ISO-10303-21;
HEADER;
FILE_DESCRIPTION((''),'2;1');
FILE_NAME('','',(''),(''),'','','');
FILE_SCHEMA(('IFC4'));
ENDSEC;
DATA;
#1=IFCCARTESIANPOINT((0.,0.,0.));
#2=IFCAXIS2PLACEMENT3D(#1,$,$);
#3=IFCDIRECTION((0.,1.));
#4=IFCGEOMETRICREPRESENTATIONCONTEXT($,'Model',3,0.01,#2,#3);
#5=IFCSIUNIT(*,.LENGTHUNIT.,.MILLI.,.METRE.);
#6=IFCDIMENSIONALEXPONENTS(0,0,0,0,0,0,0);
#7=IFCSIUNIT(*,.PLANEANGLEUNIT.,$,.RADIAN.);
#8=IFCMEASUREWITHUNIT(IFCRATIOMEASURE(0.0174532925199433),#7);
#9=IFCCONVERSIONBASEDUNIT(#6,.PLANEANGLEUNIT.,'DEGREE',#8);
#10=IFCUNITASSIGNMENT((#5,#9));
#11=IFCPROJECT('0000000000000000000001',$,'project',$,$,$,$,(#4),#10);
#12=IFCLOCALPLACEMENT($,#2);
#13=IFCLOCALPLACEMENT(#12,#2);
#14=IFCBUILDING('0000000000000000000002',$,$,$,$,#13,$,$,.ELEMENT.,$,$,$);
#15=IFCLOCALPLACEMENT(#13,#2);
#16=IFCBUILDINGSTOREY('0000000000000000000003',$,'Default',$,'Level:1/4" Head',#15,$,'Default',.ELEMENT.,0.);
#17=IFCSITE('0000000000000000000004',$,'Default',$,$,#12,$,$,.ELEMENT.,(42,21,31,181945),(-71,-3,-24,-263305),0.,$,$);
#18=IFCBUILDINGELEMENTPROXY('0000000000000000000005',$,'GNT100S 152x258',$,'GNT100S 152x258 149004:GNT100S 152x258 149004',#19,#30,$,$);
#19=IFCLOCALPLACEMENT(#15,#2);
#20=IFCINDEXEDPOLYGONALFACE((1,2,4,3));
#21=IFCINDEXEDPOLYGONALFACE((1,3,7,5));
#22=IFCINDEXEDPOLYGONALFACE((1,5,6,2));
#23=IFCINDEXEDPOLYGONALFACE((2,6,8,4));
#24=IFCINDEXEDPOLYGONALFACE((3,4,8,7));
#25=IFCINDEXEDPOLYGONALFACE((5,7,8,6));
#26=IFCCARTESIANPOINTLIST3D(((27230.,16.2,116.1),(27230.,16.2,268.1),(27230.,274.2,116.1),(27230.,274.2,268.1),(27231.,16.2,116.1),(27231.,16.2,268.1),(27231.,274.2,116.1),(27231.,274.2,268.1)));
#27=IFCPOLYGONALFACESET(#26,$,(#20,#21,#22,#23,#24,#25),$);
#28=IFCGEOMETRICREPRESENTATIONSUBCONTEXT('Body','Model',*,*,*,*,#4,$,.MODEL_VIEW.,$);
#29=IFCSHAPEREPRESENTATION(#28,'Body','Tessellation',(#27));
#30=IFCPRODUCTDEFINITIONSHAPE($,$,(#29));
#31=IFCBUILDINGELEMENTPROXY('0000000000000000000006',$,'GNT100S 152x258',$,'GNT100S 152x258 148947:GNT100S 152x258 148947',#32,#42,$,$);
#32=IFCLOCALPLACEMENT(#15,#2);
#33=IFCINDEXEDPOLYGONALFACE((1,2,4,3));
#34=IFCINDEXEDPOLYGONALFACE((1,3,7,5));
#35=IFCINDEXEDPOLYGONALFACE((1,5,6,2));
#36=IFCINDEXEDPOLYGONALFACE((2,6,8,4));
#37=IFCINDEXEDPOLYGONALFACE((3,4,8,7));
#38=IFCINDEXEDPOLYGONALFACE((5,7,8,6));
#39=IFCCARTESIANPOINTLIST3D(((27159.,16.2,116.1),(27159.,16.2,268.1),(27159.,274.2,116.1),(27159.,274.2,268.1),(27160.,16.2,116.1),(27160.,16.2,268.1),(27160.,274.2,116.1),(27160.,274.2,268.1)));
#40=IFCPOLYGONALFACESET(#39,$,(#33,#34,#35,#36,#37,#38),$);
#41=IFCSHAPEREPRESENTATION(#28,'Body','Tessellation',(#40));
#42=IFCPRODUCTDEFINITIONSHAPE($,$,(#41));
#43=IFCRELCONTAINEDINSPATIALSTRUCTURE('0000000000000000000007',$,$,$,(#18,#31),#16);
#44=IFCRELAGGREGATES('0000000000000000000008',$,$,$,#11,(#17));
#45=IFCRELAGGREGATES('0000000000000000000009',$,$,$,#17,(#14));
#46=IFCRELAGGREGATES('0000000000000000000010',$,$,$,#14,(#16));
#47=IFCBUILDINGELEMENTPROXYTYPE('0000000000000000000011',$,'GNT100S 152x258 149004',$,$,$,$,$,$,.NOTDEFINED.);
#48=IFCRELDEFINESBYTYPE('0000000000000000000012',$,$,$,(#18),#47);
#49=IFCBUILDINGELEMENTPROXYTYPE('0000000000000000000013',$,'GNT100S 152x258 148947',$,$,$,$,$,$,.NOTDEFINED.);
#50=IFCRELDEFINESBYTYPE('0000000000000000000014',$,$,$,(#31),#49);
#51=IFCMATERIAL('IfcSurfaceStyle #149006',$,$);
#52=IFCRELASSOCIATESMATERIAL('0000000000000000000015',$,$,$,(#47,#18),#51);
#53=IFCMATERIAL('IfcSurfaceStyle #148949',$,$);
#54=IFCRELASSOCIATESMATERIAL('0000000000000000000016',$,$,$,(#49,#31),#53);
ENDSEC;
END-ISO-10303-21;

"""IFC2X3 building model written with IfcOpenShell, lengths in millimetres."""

from ifc_helpers import new_model, entity, si_unit, converted_unit, direction, frame, origin, origin_2d_with_axis, place, context, subcontext, project, spatial, rectangle, extrude, source, transform, mapped, material, type_object, type_shapes, element, save


model = new_model("IFC2X3")

# Units and contexts
model_context = context("Model", 3, precision=0.01, world=origin(), true_north=direction((0.0, 1.0)))
body_context = subcontext(model_context, "Body", "Model", "MODEL_VIEW")
ifc_project = project(units=[si_unit("LENGTHUNIT", "METRE", prefix="MILLI"), converted_unit("PLANEANGLEUNIT", "DEGREE", entity("IfcRatioMeasure", 0.0174532925199433), si_unit("PLANEANGLEUNIT", "RADIAN"), dimensions=[0, 0, 0, 0, 0, 0, 0])], contexts=[model_context])

# Site, building, storey
site_placement = place(None, origin())
site = spatial("IfcSite", under=ifc_project, at=site_placement, Name="Default", CompositionType="ELEMENT", RefLatitude=(42, 21, 31, 181945), RefLongitude=(-71, -3, -24, -263305), RefElevation=0.0)
building_placement = place(site_placement, origin())
building = spatial("IfcBuilding", under=site, at=building_placement, CompositionType="ELEMENT")
storey_placement = place(building_placement, origin())
storey = spatial("IfcBuildingStorey", under=building, at=storey_placement, Name="Default", ObjectType="Level:1/4\" Head", LongName="Default", CompositionType="ELEMENT", Elevation=0.0)

# Building element proxies
ifc_material_1 = material(Name="IfcSurfaceStyle #149006")
building_element_proxy_type_1 = type_object("IfcBuildingElementProxyType", Name="GNT100S 152x258 149004", PredefinedType="NOTDEFINED", material=ifc_material_1)
shared_shape_1 = source(origin(), body_context, "Body", "SweptSolid", [
    extrude(rectangle(XDim=258.0, YDim=152.0, at=origin_2d_with_axis()), frame((129.0, 76.0, 0.0), z_axis=(0.0, 0.0, 1.0), x_axis=(-1.0, 0.0, 0.0)), (0.0, 0.0, 1.0), 1.0),
])
type_shapes(building_element_proxy_type_1, [shared_shape_1])
proxy_1_placement = place(building_placement, frame((27231.0, 16.2, 268.1), z_axis=(-1.0, 0.0, 0.0), x_axis=(0.0, 1.0, 0.0)))
element("IfcBuildingElementProxy", 1, at=proxy_1_placement, inside=storey, type_object=building_element_proxy_type_1, material=ifc_material_1, Name="GNT100S 152x258", ObjectType="GNT100S 152x258 149004:GNT100S 152x258 149004", context=body_context, shape_type="MappedRepresentation", body=[
    mapped(shared_shape_1, transform((0.0, 0.0, 0.0), scale=1.0)),
])
ifc_material_2 = material(Name="IfcSurfaceStyle #148949")
building_element_proxy_type_2 = type_object("IfcBuildingElementProxyType", Name="GNT100S 152x258 148947", PredefinedType="NOTDEFINED", material=ifc_material_2)
shared_shape_2 = source(origin(), body_context, "Body", "SweptSolid", [
    extrude(rectangle(XDim=258.0, YDim=152.0, at=origin_2d_with_axis()), frame((129.0, 76.0, 0.0), z_axis=(0.0, 0.0, 1.0), x_axis=(-1.0, 0.0, 0.0)), (0.0, 0.0, 1.0), 1.0),
])
type_shapes(building_element_proxy_type_2, [shared_shape_2])
proxy_2_placement = place(building_placement, frame((27160.0, 16.2, 268.1), z_axis=(-1.0, 0.0, 0.0), x_axis=(0.0, 1.0, 0.0)))
element("IfcBuildingElementProxy", 2, at=proxy_2_placement, inside=storey, type_object=building_element_proxy_type_2, material=ifc_material_2, Name="GNT100S 152x258", ObjectType="GNT100S 152x258 148947:GNT100S 152x258 148947", context=body_context, shape_type="MappedRepresentation", body=[
    mapped(shared_shape_2, transform((0.0, 0.0, 0.0), scale=1.0)),
])

save(model, "model.ifc")
